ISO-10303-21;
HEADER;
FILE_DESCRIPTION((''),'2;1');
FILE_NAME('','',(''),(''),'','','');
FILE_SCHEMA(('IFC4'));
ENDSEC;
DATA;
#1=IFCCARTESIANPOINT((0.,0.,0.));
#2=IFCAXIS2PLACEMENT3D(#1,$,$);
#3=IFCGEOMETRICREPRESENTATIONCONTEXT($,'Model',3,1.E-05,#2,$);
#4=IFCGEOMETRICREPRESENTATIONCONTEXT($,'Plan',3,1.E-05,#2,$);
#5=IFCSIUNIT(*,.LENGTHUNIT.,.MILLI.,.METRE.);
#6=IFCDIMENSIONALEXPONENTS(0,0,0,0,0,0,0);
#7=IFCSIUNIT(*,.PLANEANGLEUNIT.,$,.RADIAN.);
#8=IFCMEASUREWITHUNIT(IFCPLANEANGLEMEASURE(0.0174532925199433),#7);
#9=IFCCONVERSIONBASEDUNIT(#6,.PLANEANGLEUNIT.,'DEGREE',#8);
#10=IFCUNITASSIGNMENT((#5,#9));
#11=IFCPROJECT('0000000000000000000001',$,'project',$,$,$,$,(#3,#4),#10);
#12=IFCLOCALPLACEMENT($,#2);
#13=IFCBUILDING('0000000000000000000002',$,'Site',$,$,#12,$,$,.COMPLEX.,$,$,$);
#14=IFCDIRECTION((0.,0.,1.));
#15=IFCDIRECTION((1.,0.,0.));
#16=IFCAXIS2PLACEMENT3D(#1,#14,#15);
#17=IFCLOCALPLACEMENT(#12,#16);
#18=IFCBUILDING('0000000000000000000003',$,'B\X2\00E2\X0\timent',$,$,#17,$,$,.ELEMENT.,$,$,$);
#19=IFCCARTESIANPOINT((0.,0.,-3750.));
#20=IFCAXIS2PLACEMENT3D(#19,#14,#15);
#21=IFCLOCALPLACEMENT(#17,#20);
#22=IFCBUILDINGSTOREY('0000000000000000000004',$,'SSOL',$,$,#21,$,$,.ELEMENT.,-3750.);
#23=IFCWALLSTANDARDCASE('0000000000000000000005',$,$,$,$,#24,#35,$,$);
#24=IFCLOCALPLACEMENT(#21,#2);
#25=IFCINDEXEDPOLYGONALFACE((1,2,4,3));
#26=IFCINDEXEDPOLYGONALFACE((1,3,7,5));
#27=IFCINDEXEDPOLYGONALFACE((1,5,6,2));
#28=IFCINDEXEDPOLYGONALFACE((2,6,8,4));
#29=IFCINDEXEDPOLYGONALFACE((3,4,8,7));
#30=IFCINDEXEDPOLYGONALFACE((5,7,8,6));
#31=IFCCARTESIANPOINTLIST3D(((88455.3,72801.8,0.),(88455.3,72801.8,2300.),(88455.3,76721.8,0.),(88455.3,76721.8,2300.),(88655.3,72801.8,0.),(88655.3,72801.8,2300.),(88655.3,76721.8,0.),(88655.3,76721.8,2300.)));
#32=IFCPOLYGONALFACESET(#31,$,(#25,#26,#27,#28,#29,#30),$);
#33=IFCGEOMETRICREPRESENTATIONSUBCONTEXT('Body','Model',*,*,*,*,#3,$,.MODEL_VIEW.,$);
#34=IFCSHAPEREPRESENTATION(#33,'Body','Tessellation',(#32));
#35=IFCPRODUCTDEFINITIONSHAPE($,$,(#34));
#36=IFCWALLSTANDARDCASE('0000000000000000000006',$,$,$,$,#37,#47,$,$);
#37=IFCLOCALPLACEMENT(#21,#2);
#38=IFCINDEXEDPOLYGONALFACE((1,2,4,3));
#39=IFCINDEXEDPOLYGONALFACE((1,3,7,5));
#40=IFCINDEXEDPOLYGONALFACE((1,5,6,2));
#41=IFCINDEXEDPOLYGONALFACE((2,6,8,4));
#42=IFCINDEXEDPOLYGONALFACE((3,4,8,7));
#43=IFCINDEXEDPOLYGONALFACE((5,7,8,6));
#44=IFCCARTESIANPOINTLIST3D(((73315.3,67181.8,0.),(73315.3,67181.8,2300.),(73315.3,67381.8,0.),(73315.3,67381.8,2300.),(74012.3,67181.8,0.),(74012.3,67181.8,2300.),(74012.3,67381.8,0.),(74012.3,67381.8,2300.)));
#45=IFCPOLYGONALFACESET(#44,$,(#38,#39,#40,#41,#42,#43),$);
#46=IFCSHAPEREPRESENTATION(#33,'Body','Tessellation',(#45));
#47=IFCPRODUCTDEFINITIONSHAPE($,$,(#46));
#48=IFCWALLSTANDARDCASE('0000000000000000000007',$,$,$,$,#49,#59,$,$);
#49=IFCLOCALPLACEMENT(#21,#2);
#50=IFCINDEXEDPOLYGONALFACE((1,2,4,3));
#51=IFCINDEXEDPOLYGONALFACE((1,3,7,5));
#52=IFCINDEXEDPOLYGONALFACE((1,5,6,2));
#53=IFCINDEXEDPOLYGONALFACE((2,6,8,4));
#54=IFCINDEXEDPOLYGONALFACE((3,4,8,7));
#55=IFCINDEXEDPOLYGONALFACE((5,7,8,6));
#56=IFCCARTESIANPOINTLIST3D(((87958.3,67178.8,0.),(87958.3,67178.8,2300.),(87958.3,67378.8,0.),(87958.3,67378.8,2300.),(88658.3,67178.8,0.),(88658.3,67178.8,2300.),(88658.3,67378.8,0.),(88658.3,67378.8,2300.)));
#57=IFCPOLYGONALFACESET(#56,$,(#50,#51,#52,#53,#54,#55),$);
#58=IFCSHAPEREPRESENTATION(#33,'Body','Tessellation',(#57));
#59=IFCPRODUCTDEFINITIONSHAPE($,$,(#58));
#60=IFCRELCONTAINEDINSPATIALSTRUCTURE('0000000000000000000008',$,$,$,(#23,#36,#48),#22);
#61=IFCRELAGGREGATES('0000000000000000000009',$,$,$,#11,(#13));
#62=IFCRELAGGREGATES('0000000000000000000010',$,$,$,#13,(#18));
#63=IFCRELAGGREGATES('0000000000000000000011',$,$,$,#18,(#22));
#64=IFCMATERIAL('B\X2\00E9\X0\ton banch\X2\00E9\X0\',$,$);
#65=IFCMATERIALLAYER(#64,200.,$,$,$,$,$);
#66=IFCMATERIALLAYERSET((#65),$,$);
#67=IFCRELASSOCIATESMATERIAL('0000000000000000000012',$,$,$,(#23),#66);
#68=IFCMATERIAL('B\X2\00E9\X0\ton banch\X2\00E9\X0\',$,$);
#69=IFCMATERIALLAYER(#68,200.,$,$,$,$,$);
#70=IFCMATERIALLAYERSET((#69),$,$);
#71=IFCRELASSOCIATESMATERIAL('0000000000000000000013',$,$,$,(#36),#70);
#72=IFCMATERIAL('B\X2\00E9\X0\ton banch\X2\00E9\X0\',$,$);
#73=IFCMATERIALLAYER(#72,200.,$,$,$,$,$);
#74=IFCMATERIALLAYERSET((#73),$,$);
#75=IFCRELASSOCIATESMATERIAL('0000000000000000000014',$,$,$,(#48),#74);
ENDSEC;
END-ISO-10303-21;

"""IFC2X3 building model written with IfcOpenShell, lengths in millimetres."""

from ifc_helpers import new_model, entity, si_unit, converted_unit, frame, frame_2d, origin, origin_with_axes, place, context, subcontext, project, spatial, rectangle, extrude, material, layer, layer_set, layer_usage, element, save


model = new_model("IFC2X3")

# Units and contexts
model_context = context("Model", 3, precision=1e-05, world=origin())
plan_context = context("Plan", 3, precision=1e-05, world=origin())
body_context = subcontext(model_context, "Body", "Model", "MODEL_VIEW")
ifc_project = project(units=[si_unit("LENGTHUNIT", "METRE", prefix="MILLI"), converted_unit("PLANEANGLEUNIT", "DEGREE", entity("IfcPlaneAngleMeasure", 0.0174532925199433), si_unit("PLANEANGLEUNIT", "RADIAN"), dimensions=[0, 0, 0, 0, 0, 0, 0])], contexts=[model_context, plan_context])

# Buildings, storey
building_1_placement = place(None, origin())
building_1 = spatial("IfcBuilding", under=ifc_project, at=building_1_placement, Name="Site", CompositionType="COMPLEX")
building_2_placement = place(building_1_placement, origin_with_axes())
building_2 = spatial("IfcBuilding", under=building_1, at=building_2_placement, Name="Bâtiment", CompositionType="ELEMENT")
storey_placement = place(building_2_placement, frame((0.0, 0.0, -3750.0), z_axis=(0.0, 0.0, 1.0), x_axis=(1.0, 0.0, 0.0)))
storey = spatial("IfcBuildingStorey", under=building_2, at=storey_placement, Name="SSOL", CompositionType="ELEMENT", Elevation=-3750.0)

# Walls
ifc_material_1 = material(Name="Béton banché")
ifc_layer_1 = layer(ifc_material_1, 200.0)
ifc_layer_set_1 = layer_set([ifc_layer_1])
ifc_layer_usage_1 = layer_usage(ifc_layer_set_1, "AXIS2", "POSITIVE", 0.0)
wall_1_placement = place(storey_placement, frame((88655.3, 72801.8, 0.0), z_axis=(0.0, 0.0, 1.0), x_axis=(0.0, 1.0, 0.0)))
element("IfcWallStandardCase", 1, at=wall_1_placement, inside=storey, material=ifc_layer_usage_1, context=body_context, shape_type="SweptSolid", body=[
    extrude(rectangle(XDim=3920.0, YDim=200.0, at=frame_2d((1960.0, 100.0), x_axis=(1.0, 0.0))), origin_with_axes(), (0.0, 0.0, 1.0), 2300.0),
])
ifc_material_2 = material(Name="Béton banché")
ifc_layer_2 = layer(ifc_material_2, 200.0)
ifc_layer_set_2 = layer_set([ifc_layer_2])
ifc_layer_usage_2 = layer_usage(ifc_layer_set_2, "AXIS2", "POSITIVE", 0.0)
wall_2_placement = place(storey_placement, frame((73315.3, 67181.8, 0.0), z_axis=(0.0, 0.0, 1.0), x_axis=(1.0, 0.0, 0.0)))
element("IfcWallStandardCase", 2, at=wall_2_placement, inside=storey, material=ifc_layer_usage_2, context=body_context, shape_type="SweptSolid", body=[
    extrude(rectangle(XDim=697.0, YDim=200.0, at=frame_2d((348.5, 100.0), x_axis=(1.0, 0.0))), origin_with_axes(), (0.0, 0.0, 1.0), 2300.0),
])
ifc_material_3 = material(Name="Béton banché")
ifc_layer_3 = layer(ifc_material_3, 200.0)
ifc_layer_set_3 = layer_set([ifc_layer_3])
ifc_layer_usage_3 = layer_usage(ifc_layer_set_3, "AXIS2", "POSITIVE", 0.0)
wall_3_placement = place(storey_placement, frame((87958.3, 67178.8, 0.0), z_axis=(0.0, 0.0, 1.0), x_axis=(1.0, 0.0, 0.0)))
element("IfcWallStandardCase", 3, at=wall_3_placement, inside=storey, material=ifc_layer_usage_3, context=body_context, shape_type="SweptSolid", body=[
    extrude(rectangle(XDim=700.0, YDim=200.0, at=frame_2d((350.0, 100.0), x_axis=(1.0, 0.0))), origin_with_axes(), (0.0, 0.0, 1.0), 2300.0),
])

save(model, "model.ifc")
